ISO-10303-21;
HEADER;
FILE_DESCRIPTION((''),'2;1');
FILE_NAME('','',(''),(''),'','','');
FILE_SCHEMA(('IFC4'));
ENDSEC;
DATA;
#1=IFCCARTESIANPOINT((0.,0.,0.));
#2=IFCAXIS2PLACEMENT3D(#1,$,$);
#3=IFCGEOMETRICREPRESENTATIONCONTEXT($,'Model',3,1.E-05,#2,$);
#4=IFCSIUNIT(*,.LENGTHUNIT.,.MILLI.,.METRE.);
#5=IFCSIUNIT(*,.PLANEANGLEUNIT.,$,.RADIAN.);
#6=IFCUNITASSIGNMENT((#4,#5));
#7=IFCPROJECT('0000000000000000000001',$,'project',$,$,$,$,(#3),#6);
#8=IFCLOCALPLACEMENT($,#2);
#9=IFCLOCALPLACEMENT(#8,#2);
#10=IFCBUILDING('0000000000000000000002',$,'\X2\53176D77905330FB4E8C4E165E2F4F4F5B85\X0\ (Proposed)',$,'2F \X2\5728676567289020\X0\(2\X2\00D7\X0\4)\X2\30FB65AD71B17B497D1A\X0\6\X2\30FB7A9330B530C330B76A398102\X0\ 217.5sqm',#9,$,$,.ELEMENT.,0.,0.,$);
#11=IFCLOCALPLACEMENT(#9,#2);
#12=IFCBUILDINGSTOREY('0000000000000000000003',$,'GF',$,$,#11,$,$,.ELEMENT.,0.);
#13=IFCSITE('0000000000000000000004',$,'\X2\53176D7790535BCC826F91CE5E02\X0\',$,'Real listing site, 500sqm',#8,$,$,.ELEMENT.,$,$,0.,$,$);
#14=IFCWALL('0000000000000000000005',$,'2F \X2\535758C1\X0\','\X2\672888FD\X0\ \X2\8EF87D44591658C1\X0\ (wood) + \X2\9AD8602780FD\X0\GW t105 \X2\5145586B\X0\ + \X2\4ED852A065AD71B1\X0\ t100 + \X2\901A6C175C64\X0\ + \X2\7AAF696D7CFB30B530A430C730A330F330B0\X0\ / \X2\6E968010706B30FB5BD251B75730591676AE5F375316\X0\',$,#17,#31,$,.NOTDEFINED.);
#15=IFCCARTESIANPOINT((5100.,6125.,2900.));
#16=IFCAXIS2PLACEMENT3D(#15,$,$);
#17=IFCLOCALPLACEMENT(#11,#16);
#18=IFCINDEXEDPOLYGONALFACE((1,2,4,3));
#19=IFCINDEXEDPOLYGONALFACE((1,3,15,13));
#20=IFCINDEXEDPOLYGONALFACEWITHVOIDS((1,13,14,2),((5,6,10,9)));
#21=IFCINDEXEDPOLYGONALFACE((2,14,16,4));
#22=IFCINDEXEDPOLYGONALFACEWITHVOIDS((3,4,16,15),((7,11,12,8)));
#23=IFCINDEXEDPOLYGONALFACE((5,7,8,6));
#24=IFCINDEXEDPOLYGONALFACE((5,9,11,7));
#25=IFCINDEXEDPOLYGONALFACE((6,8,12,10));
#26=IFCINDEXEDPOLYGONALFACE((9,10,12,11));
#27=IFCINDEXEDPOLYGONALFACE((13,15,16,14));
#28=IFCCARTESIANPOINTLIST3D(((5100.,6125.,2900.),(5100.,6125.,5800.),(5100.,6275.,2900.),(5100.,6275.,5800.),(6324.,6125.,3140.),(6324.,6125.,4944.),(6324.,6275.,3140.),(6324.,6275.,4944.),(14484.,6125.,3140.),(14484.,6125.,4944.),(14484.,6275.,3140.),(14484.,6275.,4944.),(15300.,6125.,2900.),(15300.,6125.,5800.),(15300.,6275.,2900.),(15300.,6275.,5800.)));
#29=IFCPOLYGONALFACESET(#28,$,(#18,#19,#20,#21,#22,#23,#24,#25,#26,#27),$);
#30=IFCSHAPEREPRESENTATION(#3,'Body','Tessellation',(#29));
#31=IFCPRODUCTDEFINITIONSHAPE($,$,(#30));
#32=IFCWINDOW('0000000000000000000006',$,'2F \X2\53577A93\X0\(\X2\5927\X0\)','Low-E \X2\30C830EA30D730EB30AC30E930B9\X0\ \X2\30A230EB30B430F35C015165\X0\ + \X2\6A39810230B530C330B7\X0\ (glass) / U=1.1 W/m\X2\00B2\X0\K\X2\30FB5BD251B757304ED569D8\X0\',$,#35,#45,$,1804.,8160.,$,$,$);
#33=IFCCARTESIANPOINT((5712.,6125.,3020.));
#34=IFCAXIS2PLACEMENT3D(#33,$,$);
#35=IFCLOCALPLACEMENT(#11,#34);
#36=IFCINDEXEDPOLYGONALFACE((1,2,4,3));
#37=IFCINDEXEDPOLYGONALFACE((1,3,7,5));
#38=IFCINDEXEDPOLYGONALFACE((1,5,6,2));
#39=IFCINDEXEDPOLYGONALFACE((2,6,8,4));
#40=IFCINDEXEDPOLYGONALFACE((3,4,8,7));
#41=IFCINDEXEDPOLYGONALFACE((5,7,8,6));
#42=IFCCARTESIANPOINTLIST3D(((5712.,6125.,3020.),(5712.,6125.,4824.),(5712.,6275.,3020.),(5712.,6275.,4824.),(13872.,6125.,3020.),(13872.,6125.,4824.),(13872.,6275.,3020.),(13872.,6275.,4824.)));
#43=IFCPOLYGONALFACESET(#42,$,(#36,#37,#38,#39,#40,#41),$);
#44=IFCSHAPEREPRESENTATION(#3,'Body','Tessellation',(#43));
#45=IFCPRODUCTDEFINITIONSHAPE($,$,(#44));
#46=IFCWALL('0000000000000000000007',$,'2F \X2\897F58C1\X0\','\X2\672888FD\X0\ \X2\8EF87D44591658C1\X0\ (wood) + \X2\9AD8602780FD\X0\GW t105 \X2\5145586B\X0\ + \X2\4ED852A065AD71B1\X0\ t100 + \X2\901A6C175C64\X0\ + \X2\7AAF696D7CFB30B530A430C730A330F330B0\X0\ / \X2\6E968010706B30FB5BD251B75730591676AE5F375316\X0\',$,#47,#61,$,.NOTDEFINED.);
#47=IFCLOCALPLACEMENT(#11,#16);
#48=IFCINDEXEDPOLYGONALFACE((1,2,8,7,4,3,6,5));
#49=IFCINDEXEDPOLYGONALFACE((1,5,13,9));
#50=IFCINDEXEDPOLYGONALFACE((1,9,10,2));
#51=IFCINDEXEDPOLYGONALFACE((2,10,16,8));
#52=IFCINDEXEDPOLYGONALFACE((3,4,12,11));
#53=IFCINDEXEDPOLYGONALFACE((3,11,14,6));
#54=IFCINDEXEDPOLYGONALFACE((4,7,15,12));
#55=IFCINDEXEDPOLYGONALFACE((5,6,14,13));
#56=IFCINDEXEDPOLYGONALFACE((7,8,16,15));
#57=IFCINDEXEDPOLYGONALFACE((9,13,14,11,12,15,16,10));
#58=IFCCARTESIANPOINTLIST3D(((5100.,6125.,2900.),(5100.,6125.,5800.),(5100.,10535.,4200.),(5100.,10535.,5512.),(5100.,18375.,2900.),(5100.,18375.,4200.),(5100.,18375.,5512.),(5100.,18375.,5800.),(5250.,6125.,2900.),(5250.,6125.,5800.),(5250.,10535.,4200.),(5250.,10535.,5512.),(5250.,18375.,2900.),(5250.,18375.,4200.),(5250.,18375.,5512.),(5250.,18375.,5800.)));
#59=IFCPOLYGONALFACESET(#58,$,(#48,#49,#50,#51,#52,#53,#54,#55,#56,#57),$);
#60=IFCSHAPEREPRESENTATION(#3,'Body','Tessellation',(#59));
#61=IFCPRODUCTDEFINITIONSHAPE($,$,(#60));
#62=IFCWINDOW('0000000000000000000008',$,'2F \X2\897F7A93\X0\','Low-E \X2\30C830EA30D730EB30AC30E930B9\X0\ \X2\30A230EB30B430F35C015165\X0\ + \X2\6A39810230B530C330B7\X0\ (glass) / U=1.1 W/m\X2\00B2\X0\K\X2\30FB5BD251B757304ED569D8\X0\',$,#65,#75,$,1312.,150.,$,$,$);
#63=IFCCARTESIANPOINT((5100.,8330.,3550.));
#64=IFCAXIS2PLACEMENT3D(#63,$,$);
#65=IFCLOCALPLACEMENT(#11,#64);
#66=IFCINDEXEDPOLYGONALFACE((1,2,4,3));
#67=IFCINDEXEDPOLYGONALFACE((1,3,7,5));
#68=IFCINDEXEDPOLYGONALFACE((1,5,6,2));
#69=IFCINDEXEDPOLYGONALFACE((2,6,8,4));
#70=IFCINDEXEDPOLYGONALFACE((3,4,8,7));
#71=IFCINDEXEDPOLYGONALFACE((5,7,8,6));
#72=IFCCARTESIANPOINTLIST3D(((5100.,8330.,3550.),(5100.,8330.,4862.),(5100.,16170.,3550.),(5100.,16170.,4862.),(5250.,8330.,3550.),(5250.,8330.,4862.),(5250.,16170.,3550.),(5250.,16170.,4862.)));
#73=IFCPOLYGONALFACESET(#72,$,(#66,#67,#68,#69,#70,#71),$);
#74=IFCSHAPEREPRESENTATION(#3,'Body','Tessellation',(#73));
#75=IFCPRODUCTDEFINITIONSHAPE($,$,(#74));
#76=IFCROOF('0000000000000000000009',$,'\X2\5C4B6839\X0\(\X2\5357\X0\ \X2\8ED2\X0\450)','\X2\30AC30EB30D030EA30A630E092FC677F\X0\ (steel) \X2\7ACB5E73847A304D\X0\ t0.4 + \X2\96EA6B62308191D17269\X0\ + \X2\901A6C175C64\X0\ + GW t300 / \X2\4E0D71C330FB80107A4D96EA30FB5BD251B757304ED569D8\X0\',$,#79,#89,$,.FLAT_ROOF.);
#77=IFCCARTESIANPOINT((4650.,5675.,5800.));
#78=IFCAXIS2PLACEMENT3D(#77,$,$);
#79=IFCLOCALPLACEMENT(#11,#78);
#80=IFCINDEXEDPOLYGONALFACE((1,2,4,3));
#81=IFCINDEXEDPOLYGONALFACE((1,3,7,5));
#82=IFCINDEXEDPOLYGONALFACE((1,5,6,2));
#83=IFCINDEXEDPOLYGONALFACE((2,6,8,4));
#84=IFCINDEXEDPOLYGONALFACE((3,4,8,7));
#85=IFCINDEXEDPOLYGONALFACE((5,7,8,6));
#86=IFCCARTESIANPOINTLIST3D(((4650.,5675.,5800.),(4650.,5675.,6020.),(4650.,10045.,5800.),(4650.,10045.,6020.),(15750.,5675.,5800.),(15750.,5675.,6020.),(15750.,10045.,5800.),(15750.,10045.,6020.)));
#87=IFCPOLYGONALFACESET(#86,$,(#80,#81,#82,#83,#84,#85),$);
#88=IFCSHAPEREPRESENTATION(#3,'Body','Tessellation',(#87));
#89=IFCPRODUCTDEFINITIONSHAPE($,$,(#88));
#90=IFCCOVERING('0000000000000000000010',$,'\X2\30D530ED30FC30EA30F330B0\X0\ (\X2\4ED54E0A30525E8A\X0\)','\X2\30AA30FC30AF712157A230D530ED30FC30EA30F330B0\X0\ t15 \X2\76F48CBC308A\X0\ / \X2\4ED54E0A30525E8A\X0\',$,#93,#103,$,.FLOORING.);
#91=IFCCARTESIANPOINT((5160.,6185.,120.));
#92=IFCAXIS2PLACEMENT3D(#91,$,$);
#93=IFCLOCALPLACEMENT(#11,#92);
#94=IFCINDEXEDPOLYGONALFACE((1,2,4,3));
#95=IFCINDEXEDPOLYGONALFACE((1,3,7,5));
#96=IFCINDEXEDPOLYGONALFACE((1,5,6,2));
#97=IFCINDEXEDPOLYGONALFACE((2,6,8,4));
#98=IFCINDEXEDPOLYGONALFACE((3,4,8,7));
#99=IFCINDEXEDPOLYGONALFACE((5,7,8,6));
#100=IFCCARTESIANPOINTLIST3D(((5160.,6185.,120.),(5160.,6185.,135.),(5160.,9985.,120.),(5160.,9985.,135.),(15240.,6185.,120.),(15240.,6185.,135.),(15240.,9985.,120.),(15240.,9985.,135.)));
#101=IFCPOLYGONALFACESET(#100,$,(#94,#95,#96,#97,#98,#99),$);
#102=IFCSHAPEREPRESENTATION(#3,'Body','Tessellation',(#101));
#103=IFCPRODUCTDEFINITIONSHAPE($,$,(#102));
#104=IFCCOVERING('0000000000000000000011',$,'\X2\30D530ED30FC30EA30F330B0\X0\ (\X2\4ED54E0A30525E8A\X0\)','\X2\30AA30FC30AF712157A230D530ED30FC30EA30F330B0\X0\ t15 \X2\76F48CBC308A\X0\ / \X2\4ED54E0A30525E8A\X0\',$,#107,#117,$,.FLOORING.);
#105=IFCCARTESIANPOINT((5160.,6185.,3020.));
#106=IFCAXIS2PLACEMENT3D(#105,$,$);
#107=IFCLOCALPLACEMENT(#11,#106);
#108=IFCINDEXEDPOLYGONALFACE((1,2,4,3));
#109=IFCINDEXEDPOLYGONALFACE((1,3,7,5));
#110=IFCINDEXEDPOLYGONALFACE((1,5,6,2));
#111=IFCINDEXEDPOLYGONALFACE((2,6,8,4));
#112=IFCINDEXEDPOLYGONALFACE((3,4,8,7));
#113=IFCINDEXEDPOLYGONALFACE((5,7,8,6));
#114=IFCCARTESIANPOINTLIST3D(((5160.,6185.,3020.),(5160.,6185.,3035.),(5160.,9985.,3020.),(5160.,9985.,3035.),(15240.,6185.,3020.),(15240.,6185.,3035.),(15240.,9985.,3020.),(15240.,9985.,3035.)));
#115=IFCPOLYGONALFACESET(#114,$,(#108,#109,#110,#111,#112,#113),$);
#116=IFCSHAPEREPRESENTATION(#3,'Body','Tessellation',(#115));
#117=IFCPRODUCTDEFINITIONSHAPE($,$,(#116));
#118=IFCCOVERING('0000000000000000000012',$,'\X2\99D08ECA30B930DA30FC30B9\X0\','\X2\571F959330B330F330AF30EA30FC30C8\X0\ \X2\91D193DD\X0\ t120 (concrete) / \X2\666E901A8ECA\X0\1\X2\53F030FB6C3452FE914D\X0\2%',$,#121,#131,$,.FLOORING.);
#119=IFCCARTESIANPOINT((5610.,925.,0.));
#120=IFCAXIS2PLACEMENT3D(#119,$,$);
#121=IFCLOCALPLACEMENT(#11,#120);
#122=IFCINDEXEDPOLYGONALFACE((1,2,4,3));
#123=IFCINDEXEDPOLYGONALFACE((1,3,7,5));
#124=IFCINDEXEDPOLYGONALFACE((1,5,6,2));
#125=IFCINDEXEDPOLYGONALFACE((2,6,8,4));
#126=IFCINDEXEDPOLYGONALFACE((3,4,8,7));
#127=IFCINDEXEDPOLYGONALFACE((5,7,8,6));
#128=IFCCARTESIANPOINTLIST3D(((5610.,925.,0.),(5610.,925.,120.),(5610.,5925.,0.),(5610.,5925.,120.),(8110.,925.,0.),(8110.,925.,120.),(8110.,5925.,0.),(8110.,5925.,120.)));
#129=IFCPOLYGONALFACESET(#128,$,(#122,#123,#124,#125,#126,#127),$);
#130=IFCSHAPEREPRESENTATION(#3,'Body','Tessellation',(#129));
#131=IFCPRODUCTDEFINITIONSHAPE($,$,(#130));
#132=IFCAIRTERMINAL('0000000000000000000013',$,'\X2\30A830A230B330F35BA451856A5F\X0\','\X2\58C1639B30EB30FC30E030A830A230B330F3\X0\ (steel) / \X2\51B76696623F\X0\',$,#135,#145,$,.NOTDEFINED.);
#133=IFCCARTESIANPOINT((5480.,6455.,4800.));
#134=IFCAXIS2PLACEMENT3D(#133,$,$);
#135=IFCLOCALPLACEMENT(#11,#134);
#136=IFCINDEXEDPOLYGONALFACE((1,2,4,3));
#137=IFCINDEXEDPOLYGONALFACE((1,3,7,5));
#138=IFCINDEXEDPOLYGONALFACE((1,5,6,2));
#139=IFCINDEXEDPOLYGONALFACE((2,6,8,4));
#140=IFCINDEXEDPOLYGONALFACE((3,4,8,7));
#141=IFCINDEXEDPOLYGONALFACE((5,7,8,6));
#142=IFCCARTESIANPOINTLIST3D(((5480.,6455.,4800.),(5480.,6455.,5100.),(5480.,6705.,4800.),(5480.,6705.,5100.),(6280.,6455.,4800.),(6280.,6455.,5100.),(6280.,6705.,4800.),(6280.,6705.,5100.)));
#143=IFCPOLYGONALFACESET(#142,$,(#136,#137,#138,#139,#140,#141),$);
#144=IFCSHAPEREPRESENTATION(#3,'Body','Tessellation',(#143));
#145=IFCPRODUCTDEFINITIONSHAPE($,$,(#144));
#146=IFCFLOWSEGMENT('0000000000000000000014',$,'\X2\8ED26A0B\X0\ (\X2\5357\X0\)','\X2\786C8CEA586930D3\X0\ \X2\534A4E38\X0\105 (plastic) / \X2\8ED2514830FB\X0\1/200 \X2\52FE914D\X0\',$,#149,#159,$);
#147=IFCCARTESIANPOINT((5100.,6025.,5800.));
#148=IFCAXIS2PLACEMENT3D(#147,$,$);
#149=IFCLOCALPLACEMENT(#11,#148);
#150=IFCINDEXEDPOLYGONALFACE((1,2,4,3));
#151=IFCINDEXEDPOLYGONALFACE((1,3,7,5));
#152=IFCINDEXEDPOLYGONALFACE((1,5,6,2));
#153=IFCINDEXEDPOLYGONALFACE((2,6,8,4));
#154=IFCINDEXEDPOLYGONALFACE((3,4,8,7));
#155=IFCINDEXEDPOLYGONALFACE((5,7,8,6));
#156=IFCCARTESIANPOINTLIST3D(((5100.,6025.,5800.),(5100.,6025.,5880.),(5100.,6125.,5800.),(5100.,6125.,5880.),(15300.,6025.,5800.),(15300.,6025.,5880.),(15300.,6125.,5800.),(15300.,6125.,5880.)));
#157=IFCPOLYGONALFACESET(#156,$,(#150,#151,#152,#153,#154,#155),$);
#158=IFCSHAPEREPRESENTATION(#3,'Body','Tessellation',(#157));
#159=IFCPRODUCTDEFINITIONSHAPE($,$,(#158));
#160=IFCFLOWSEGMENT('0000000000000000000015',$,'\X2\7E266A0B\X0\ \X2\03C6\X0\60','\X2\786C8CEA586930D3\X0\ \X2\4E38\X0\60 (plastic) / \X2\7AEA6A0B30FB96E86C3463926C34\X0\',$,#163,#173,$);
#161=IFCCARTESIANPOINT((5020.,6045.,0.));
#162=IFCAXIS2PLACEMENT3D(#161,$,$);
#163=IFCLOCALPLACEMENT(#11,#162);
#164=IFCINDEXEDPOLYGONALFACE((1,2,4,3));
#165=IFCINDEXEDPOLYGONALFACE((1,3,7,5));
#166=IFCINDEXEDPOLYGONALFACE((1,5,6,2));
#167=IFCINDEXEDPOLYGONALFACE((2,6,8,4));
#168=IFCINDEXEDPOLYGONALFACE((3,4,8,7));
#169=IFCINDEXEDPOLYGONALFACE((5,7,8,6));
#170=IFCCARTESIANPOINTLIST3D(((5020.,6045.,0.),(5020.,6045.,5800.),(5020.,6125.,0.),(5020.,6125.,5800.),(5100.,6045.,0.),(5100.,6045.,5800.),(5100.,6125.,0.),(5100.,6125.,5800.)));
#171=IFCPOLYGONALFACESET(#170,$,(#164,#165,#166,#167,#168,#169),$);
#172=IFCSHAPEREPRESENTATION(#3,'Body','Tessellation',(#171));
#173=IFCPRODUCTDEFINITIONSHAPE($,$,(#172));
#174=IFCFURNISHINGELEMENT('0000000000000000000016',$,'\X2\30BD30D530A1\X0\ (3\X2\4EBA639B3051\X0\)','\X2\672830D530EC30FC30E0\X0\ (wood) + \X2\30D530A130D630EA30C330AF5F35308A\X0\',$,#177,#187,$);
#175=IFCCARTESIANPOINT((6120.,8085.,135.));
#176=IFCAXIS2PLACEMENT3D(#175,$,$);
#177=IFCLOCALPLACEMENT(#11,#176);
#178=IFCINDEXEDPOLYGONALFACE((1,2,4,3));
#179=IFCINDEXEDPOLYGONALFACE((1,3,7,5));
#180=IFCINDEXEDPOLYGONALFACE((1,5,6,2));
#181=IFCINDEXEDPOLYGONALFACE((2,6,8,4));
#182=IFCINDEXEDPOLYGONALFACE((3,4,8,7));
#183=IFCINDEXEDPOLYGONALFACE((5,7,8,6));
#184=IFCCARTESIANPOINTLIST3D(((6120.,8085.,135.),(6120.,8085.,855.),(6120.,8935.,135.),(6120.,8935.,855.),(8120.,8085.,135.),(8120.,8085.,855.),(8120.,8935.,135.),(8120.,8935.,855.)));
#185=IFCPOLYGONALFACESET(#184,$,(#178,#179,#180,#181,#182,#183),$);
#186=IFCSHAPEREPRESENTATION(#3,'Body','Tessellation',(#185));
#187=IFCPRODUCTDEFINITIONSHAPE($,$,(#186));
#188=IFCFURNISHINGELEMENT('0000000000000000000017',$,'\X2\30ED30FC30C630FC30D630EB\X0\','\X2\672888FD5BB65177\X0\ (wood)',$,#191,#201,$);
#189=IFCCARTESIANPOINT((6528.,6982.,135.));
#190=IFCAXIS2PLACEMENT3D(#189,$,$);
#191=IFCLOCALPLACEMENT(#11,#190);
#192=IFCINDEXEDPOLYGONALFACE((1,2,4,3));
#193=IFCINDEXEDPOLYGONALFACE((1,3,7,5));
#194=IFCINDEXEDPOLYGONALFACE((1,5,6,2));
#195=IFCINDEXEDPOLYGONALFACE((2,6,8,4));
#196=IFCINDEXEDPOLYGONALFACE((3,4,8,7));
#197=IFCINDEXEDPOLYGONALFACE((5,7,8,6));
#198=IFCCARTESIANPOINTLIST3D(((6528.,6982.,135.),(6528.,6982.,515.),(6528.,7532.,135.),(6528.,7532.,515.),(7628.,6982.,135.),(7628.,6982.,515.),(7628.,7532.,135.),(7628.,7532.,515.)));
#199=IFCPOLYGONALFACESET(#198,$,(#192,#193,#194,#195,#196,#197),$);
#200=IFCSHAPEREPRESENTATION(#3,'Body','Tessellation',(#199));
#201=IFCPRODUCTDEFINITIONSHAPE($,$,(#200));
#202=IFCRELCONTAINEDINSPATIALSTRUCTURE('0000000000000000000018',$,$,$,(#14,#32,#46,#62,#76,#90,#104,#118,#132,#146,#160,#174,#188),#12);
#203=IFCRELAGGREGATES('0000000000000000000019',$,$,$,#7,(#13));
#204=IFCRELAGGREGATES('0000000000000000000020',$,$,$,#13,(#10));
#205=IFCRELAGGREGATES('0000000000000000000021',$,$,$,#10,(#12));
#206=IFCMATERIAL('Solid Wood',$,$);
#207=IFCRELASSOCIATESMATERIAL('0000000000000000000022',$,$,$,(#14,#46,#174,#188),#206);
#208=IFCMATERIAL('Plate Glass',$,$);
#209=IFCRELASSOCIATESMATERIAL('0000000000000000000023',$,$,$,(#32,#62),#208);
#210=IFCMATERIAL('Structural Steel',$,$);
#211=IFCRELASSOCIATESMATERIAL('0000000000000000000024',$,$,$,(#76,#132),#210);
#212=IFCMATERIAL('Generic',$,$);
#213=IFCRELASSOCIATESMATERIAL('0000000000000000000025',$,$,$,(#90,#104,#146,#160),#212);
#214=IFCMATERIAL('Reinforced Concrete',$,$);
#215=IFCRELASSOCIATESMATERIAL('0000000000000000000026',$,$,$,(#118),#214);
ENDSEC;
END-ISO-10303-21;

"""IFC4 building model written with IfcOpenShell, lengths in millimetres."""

from ifc_helpers import new_model, si_unit, frame, frame_2d, origin, place, context, project, spatial, rectangle, extrude, material, element, fill, save


model = new_model("IFC4")

# Units and contexts
model_context = context("Model", 3, precision=1e-05, world=origin())
ifc_project = project(units=[si_unit("LENGTHUNIT", "METRE", prefix="MILLI"), si_unit("PLANEANGLEUNIT", "RADIAN")], contexts=[model_context])

# Site, building, storey
site_placement = place(None, origin())
site = spatial("IfcSite", under=ifc_project, at=site_placement, Name="北海道富良野市", ObjectType="Real listing site, 500sqm", CompositionType="ELEMENT", RefElevation=0.0)
building_placement = place(site_placement, origin())
building = spatial("IfcBuilding", under=site, at=building_placement, Name="北海道・二世帯住宅 (Proposed)", ObjectType="2F 在来木造(2×4)・断熱等級6・窓サッシ樹脂 217.5sqm", CompositionType="ELEMENT", ElevationOfRefHeight=0.0, ElevationOfTerrain=0.0)
storey_placement = place(building_placement, origin())
storey = spatial("IfcBuildingStorey", under=building, at=storey_placement, Name="GF", CompositionType="ELEMENT", Elevation=0.0)

# Shared definitions
ifc_material_1 = material(Name="Solid Wood")

# Shared definitions
ifc_material_2 = material(Name="Reinforced Concrete")

# Shared definitions
ifc_material_3 = material(Name="Plate Glass")

# Walls, openings, windows
wall_1_placement = place(storey_placement, frame((5100.0, 6125.0, 2900.0)))
wall_1 = element("IfcWall", 1, at=wall_1_placement, inside=storey, material=ifc_material_1, Name="2F 南壁", Description="木製 軸組外壁 (wood) + 高性能GW t105 充填 + 付加断熱 t100 + 通気層 + 窯業系サイディング / 準耐火・寒冷地外皮強化", PredefinedType="NOTDEFINED", context=model_context, shape_type="SweptSolid", body=[
    extrude(rectangle(XDim=10200.0, YDim=150.0, at=frame_2d((5100.0, 75.0))), frame((5100.0, 6125.0, 2900.0)), (0.0, 0.0, 1.0), 2900.0),
])
opening_1_placement = place(storey_placement, frame((5712.0, 6125.0, 3020.0)))
opening_1 = element("IfcOpeningElement", 2, at=opening_1_placement, cuts=wall_1, PredefinedType="NOTDEFINED", context=model_context, shape_type="SweptSolid", body=[
    extrude(rectangle(XDim=8160.0, YDim=150.0, at=frame_2d((4080.0, 75.0))), frame((5712.0, 6125.0, 3020.0)), (0.0, 0.0, 1.0), 1804.0),
])
window_1_placement = place(storey_placement, frame((5712.0, 6125.0, 3020.0)))
window_1 = element("IfcWindow", 3, at=window_1_placement, inside=storey, material=ifc_material_3, Name="2F 南窓(大)", Description="Low-E トリプルガラス アルゴン封入 + 樹脂サッシ (glass) / U=1.1 W/m²K・寒冷地仕様", OverallHeight=1804.0, OverallWidth=8160.0, context=model_context, shape_type="SweptSolid", body=[
    extrude(rectangle(XDim=8160.0, YDim=150.0, at=frame_2d((4080.0, 75.0))), frame((5712.0, 6125.0, 3020.0)), (0.0, 0.0, 1.0), 1804.0),
])
fill(opening_1, window_1)
wall_2_placement = place(storey_placement, frame((5100.0, 6125.0, 2900.0)))
wall_2 = element("IfcWall", 4, at=wall_2_placement, inside=storey, material=ifc_material_1, Name="2F 西壁", Description="木製 軸組外壁 (wood) + 高性能GW t105 充填 + 付加断熱 t100 + 通気層 + 窯業系サイディング / 準耐火・寒冷地外皮強化", PredefinedType="NOTDEFINED", context=model_context, shape_type="SweptSolid", body=[
    extrude(rectangle(XDim=150.0, YDim=12250.0, at=frame_2d((75.0, 6125.0))), frame((5100.0, 6125.0, 2900.0)), (0.0, 0.0, 1.0), 2900.0),
])
opening_2_placement = place(storey_placement, frame((5100.0, 8330.0, 3550.0)))
opening_2 = element("IfcOpeningElement", 5, at=opening_2_placement, cuts=wall_2, PredefinedType="NOTDEFINED", context=model_context, shape_type="SweptSolid", body=[
    extrude(rectangle(XDim=150.0, YDim=7840.0, at=frame_2d((75.0, 3920.0))), frame((5100.0, 8330.0, 3550.0)), (0.0, 0.0, 1.0), 1312.0),
])
window_2_placement = place(storey_placement, frame((5100.0, 8330.0, 3550.0)))
window_2 = element("IfcWindow", 6, at=window_2_placement, inside=storey, material=ifc_material_3, Name="2F 西窓", Description="Low-E トリプルガラス アルゴン封入 + 樹脂サッシ (glass) / U=1.1 W/m²K・寒冷地仕様", OverallHeight=1312.0, OverallWidth=150.0, context=model_context, shape_type="SweptSolid", body=[
    extrude(rectangle(XDim=150.0, YDim=7840.0, at=frame_2d((75.0, 3920.0))), frame((5100.0, 8330.0, 3550.0)), (0.0, 0.0, 1.0), 1312.0),
])
fill(opening_2, window_2)

# Roof
ifc_material_4 = material(Name="Structural Steel")
for number, where, name in (
    (7, (4650.0, 5675.0, 5800.0), "屋根(南 軒450)"),
):
    element("IfcRoof", number, at=place(storey_placement, frame(where)), inside=storey, material=ifc_material_4, Name=name, Description="ガルバリウム鋼板 (steel) 立平葺き t0.4 + 雪止め金物 + 通気層 + GW t300 / 不燃・耐積雪・寒冷地仕様", PredefinedType="FLAT_ROOF", context=model_context, shape_type="SweptSolid", body=[
        extrude(rectangle(XDim=11100.0, YDim=4370.0, at=frame_2d((5550.0, 2185.0))), frame((4650.0, 5675.0, 5800.0)), (0.0, 0.0, 1.0), 220.0),
    ])

# Coverings
ifc_material_5 = material(Name="Generic")
covering_1_placement = place(storey_placement, frame((5160.0, 6185.0, 120.0)))
element("IfcCovering", 8, at=covering_1_placement, inside=storey, material=ifc_material_5, Name="フローリング (仕上げ床)", Description="オーク無垢フローリング t15 直貼り / 仕上げ床", PredefinedType="FLOORING", context=model_context, shape_type="SweptSolid", body=[
    extrude(rectangle(XDim=10080.0, YDim=3800.0, at=frame_2d((5040.0, 1900.0))), frame((5160.0, 6185.0, 120.0)), (0.0, 0.0, 1.0), 15.0),
])
covering_2_placement = place(storey_placement, frame((5160.0, 6185.0, 3020.0)))
element("IfcCovering", 9, at=covering_2_placement, inside=storey, material=ifc_material_5, Name="フローリング (仕上げ床)", Description="オーク無垢フローリング t15 直貼り / 仕上げ床", PredefinedType="FLOORING", context=model_context, shape_type="SweptSolid", body=[
    extrude(rectangle(XDim=10080.0, YDim=3800.0, at=frame_2d((5040.0, 1900.0))), frame((5160.0, 6185.0, 3020.0)), (0.0, 0.0, 1.0), 15.0),
])
covering_3_placement = place(storey_placement, frame((5610.0, 925.0, 0.0)))
element("IfcCovering", 10, at=covering_3_placement, inside=storey, material=ifc_material_2, Name="駐車スペース", Description="土間コンクリート 金鏝 t120 (concrete) / 普通車1台・水勾配2%", PredefinedType="FLOORING", context=model_context, shape_type="SweptSolid", body=[
    extrude(rectangle(XDim=2500.0, YDim=5000.0, at=frame_2d((1250.0, 2500.0))), frame((5610.0, 925.0, 0.0)), (0.0, 0.0, 1.0), 120.0),
])

# Air terminal
air_terminal_placement = place(storey_placement, frame((5480.0, 6455.0, 4800.0)))
element("IfcAirTerminal", 11, at=air_terminal_placement, inside=storey, material=ifc_material_4, Name="エアコン室内機", Description="壁掛ルームエアコン (steel) / 冷暖房", PredefinedType="NOTDEFINED", context=model_context, shape_type="SweptSolid", body=[
    extrude(rectangle(XDim=800.0, YDim=250.0, at=frame_2d((400.0, 125.0))), frame((5480.0, 6455.0, 4800.0)), (0.0, 0.0, 1.0), 300.0),
])

# Flow segments
flow_segment_1_placement = place(storey_placement, frame((5100.0, 6025.0, 5800.0)))
element("IfcFlowSegment", 12, at=flow_segment_1_placement, inside=storey, material=ifc_material_5, Name="軒樋 (南)", Description="硬質塩ビ 半丸105 (plastic) / 軒先・1/200 勾配", context=model_context, shape_type="SweptSolid", body=[
    extrude(rectangle(XDim=10200.0, YDim=100.0, at=frame_2d((5100.0, 50.0))), frame((5100.0, 6025.0, 5800.0)), (0.0, 0.0, 1.0), 80.0),
])
flow_segment_2_placement = place(storey_placement, frame((5020.0, 6045.0, 0.0)))
element("IfcFlowSegment", 13, at=flow_segment_2_placement, inside=storey, material=ifc_material_5, Name="縦樋 φ60", Description="硬質塩ビ 丸60 (plastic) / 竪樋・雨水排水", context=model_context, shape_type="SweptSolid", body=[
    extrude(rectangle(XDim=80.0, YDim=80.0, at=frame_2d((40.0, 40.0))), frame((5020.0, 6045.0, 0.0)), (0.0, 0.0, 1.0), 5800.0),
])

# Furnishing elements
furnishing_1_placement = place(storey_placement, frame((6120.0, 8085.0, 135.0)))
element("IfcFurnishingElement", 14, at=furnishing_1_placement, inside=storey, material=ifc_material_1, Name="ソファ (3人掛け)", Description="木フレーム (wood) + ファブリック張り", context=model_context, shape_type="SweptSolid", body=[
    extrude(rectangle(XDim=2000.0, YDim=850.0, at=frame_2d((1000.0, 425.0))), frame((6120.0, 8085.0, 135.0)), (0.0, 0.0, 1.0), 720.0),
])
furnishing_2_placement = place(storey_placement, frame((6528.0, 6982.0, 135.0)))
element("IfcFurnishingElement", 15, at=furnishing_2_placement, inside=storey, material=ifc_material_1, Name="ローテーブル", Description="木製家具 (wood)", context=model_context, shape_type="SweptSolid", body=[
    extrude(rectangle(XDim=1100.0, YDim=550.0, at=frame_2d((550.0, 275.0))), frame((6528.0, 6982.0, 135.0)), (0.0, 0.0, 1.0), 380.0),
])

save(model, "model.ifc")
